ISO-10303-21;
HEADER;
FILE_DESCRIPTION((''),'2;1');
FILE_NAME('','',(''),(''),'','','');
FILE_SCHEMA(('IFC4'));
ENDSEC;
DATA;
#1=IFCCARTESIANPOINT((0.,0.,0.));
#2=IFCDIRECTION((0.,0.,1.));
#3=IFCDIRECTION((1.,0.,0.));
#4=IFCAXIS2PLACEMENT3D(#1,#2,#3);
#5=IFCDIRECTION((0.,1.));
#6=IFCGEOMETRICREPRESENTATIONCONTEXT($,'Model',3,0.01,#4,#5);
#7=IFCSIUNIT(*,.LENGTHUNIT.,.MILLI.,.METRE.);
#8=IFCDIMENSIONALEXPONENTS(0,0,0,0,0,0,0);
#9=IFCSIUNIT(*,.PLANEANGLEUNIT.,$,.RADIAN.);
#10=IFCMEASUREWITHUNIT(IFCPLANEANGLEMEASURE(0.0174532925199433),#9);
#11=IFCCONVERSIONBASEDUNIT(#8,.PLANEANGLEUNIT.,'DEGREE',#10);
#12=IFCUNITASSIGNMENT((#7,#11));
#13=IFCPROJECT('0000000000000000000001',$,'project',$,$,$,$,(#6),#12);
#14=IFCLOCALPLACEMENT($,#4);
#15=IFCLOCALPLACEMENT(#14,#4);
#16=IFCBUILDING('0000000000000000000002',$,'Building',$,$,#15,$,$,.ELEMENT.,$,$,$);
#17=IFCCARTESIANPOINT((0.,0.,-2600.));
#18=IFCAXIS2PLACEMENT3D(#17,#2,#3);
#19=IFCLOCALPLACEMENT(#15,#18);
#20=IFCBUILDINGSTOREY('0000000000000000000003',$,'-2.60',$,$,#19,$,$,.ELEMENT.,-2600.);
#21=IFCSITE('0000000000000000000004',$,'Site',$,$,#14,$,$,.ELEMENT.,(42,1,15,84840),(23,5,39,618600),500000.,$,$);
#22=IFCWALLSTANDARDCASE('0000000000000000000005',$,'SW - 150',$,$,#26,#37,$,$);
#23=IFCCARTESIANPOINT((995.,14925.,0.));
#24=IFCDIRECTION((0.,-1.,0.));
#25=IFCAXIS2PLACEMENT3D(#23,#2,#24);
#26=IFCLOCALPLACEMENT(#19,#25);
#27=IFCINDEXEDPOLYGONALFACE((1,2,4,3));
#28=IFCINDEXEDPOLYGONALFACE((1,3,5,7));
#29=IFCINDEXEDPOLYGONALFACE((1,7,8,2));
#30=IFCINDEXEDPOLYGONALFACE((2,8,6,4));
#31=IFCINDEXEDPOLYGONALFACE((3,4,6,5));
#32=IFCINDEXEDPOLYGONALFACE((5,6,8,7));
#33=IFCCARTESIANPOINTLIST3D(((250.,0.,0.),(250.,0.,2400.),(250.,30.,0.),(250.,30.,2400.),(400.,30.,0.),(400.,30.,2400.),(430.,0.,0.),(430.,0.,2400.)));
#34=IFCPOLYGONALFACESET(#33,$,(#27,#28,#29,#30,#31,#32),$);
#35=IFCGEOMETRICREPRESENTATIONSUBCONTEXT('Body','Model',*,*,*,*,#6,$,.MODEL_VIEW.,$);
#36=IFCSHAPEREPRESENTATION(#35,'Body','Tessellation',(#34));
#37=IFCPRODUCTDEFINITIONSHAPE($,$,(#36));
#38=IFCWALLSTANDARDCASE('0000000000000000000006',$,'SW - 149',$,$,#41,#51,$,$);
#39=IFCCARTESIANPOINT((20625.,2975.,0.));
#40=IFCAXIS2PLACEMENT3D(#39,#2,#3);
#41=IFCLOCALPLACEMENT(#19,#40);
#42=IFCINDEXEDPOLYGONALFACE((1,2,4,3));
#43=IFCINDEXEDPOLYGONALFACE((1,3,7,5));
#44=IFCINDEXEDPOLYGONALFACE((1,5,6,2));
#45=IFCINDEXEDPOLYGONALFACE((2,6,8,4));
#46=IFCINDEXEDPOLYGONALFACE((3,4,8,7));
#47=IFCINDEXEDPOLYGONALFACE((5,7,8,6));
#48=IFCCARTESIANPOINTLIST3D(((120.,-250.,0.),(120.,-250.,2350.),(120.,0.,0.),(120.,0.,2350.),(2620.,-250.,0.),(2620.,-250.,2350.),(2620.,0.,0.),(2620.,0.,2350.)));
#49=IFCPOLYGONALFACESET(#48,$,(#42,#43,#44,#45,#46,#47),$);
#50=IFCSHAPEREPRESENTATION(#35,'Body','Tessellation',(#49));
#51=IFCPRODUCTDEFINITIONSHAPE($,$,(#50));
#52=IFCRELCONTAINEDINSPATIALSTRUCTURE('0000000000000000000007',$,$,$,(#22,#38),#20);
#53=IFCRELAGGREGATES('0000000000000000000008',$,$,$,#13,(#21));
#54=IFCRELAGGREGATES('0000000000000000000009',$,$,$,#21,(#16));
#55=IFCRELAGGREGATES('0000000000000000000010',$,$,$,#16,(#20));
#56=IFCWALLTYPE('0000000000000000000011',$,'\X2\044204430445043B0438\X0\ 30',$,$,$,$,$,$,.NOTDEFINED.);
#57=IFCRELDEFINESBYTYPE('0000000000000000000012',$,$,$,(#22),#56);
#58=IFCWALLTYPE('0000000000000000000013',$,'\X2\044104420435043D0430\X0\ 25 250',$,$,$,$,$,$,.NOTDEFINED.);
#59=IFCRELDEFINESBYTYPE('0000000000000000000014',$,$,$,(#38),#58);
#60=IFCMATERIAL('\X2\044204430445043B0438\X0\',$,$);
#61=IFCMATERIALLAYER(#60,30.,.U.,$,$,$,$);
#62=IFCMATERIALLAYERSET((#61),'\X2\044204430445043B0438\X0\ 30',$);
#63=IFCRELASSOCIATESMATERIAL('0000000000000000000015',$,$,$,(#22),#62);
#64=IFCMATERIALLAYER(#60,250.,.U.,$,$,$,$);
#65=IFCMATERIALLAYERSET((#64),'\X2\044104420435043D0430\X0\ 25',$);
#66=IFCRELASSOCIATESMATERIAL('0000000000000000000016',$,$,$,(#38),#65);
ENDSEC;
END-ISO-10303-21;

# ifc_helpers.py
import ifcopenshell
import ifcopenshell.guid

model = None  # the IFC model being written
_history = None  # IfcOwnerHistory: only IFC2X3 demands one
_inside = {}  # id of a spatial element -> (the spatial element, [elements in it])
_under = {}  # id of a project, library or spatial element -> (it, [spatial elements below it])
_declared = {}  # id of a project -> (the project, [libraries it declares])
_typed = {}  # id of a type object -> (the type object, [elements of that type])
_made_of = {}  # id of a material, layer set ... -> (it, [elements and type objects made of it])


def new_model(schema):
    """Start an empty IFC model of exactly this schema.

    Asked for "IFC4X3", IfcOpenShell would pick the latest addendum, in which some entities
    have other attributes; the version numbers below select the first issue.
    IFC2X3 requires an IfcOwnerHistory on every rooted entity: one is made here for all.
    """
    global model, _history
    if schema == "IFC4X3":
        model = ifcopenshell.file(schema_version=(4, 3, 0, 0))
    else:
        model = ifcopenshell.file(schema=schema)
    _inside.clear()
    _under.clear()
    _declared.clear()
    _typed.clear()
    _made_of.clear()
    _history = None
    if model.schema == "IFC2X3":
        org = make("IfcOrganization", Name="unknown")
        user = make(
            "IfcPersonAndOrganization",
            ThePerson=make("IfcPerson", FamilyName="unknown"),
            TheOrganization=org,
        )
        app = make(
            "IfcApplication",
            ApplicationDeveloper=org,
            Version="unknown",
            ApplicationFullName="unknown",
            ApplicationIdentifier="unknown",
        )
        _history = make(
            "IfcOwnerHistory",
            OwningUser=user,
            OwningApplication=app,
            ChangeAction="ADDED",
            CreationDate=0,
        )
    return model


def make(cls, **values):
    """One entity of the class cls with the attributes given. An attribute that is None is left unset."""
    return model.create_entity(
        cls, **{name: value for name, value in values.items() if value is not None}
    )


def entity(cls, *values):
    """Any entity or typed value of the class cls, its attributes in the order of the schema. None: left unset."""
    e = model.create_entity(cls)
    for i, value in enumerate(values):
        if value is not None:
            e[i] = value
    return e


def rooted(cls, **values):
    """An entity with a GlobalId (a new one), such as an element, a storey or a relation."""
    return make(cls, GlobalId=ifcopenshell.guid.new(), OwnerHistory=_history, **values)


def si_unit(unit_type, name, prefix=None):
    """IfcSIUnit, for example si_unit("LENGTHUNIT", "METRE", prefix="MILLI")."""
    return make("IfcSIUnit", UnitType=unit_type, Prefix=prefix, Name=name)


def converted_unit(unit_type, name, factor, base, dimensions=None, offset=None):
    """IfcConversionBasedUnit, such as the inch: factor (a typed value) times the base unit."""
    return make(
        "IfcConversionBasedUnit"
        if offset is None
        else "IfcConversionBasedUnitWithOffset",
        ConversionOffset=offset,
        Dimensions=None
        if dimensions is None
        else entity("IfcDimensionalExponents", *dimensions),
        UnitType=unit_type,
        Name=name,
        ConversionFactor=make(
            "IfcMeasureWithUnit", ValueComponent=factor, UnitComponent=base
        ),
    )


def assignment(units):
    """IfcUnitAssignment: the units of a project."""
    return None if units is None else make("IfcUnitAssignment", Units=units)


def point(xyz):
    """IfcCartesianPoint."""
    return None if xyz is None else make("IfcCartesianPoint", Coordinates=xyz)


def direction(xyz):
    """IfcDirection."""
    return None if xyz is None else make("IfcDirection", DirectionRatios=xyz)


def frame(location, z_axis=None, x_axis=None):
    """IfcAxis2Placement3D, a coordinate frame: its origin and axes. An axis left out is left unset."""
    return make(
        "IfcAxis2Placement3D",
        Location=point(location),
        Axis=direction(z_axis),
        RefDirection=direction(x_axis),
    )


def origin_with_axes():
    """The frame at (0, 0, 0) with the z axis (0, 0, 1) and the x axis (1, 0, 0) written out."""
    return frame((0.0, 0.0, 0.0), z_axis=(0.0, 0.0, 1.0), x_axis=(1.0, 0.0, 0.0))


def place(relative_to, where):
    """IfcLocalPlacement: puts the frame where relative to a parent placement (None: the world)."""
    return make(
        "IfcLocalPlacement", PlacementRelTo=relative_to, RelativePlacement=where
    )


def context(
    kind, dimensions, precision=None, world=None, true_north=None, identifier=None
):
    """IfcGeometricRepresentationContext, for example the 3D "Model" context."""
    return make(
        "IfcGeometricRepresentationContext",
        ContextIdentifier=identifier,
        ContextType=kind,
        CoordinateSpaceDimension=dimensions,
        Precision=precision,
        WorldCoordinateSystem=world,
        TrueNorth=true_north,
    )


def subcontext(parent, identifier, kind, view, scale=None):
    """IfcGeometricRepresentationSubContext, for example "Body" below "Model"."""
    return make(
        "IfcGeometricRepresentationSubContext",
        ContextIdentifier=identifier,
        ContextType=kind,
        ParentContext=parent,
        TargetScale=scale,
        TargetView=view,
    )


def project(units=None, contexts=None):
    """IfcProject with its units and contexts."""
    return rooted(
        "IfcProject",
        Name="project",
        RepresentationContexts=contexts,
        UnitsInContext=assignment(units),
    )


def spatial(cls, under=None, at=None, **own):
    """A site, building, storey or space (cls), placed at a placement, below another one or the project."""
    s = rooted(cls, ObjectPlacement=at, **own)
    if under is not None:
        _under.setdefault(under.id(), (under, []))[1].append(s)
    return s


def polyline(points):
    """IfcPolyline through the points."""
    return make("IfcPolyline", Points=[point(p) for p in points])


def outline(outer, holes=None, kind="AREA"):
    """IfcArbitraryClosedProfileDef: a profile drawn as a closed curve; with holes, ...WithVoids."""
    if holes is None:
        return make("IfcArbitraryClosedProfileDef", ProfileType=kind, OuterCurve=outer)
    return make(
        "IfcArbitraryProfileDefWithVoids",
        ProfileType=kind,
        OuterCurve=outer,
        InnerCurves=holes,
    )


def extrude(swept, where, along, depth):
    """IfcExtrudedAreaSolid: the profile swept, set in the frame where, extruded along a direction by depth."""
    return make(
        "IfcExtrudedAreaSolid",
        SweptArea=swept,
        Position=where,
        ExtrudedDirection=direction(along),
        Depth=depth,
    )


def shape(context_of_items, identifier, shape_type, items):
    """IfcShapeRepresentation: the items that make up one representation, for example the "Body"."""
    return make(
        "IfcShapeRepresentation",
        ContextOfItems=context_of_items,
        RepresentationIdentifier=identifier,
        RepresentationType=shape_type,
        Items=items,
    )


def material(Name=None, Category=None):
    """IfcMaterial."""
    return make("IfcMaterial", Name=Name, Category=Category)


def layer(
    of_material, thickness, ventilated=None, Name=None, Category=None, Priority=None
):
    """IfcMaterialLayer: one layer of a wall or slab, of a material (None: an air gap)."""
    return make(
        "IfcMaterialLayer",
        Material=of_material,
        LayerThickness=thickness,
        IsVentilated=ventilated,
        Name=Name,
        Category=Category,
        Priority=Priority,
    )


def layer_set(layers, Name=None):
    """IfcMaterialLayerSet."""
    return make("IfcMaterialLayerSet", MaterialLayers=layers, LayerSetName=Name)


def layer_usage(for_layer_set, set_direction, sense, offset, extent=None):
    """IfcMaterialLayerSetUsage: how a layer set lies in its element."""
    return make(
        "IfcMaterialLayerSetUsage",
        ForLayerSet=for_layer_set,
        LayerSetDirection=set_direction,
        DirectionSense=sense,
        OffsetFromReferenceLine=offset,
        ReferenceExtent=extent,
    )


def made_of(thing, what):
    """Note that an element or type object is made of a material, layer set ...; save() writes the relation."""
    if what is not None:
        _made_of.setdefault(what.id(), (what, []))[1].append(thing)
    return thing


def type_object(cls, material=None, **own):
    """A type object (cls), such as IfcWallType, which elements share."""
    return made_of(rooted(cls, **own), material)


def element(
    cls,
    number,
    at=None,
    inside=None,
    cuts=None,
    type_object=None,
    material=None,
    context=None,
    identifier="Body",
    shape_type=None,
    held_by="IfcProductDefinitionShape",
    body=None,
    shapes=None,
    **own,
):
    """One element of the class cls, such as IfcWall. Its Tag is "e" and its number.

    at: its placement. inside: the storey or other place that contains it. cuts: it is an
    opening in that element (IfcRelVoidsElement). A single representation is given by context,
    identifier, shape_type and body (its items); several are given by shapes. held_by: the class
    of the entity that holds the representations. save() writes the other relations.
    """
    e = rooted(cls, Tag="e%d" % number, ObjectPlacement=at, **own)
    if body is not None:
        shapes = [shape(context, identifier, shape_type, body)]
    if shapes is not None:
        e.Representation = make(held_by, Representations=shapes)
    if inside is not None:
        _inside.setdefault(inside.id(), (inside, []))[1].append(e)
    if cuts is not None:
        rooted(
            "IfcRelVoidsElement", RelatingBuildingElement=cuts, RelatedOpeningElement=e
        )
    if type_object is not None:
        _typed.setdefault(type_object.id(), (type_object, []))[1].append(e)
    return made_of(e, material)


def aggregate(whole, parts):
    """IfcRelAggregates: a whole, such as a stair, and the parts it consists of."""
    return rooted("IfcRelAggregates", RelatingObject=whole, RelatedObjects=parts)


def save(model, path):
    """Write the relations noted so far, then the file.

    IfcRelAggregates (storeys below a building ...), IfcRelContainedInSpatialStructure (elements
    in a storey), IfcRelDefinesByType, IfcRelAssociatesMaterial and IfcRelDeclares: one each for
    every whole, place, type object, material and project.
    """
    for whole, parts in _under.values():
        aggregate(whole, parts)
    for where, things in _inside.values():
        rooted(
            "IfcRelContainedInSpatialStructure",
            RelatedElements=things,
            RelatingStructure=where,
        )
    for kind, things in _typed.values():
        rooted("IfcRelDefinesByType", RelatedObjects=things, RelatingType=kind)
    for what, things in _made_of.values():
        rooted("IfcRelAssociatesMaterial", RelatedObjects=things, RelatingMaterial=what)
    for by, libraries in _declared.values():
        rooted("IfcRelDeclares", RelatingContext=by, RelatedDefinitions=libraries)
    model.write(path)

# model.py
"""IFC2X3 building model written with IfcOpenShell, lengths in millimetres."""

from ifc_helpers import new_model, entity, si_unit, converted_unit, direction, frame, origin_with_axes, place, context, subcontext, project, spatial, polyline, outline, extrude, material, layer, layer_set, layer_usage, type_object, element, save


model = new_model("IFC2X3")

# Units and contexts
model_context = context("Model", 3, precision=0.01, world=origin_with_axes(), true_north=direction((0.0, 1.0)))
body_context = subcontext(model_context, "Body", "Model", "MODEL_VIEW")
ifc_project = project(units=[si_unit("LENGTHUNIT", "METRE", prefix="MILLI"), converted_unit("PLANEANGLEUNIT", "DEGREE", entity("IfcPlaneAngleMeasure", 0.0174532925199433), si_unit("PLANEANGLEUNIT", "RADIAN"), dimensions=[0, 0, 0, 0, 0, 0, 0])], contexts=[model_context])

# Site, building, storey
site_placement = place(None, origin_with_axes())
site = spatial("IfcSite", under=ifc_project, at=site_placement, Name="Site", CompositionType="ELEMENT", RefLatitude=(42, 1, 15, 84840), RefLongitude=(23, 5, 39, 618600), RefElevation=500000.0)
building_placement = place(site_placement, origin_with_axes())
building = spatial("IfcBuilding", under=site, at=building_placement, Name="Building", CompositionType="ELEMENT")
storey_placement = place(building_placement, frame((0.0, 0.0, -2600.0), z_axis=(0.0, 0.0, 1.0), x_axis=(1.0, 0.0, 0.0)))
storey = spatial("IfcBuildingStorey", under=building, at=storey_placement, Name="-2.60", CompositionType="ELEMENT", Elevation=-2600.0)

# Shared definitions
ifc_material_1 = material(Name="тухли")

# Wall
ifc_layer_1 = layer(ifc_material_1, 30.0, ventilated="UNKNOWN")
ifc_layer_set_1 = layer_set([ifc_layer_1], Name="тухли 30")
wall_type_1 = type_object("IfcWallType", Name="тухли 30", PredefinedType="NOTDEFINED")
ifc_layer_usage_1 = layer_usage(ifc_layer_set_1, "AXIS2", "POSITIVE", 0.0)
wall_1_placement = place(storey_placement, frame((995.0, 14925.0, 0.0), z_axis=(0.0, 0.0, 1.0), x_axis=(0.0, -1.0, 0.0)))
element("IfcWallStandardCase", 1, at=wall_1_placement, inside=storey, type_object=wall_type_1, material=ifc_layer_usage_1, Name="SW - 150", context=body_context, shape_type="SweptSolid", body=[
    extrude(outline(polyline([(250.0, 0.0), (430.0, 0.0), (400.0, 30.0), (250.0, 30.0), (250.0, 0.0)])), origin_with_axes(), (0.0, 0.0, 1.0), 2400.0),
])

# Shared definitions
ifc_layer_2 = layer(ifc_material_1, 250.0, ventilated="UNKNOWN")
ifc_layer_set_2 = layer_set([ifc_layer_2], Name="стена 25")
wall_type_2 = type_object("IfcWallType", Name="стена 25 250", PredefinedType="NOTDEFINED")

# Wall
ifc_layer_usage_2 = layer_usage(ifc_layer_set_2, "AXIS2", "NEGATIVE", 0.0)
wall_2_placement = place(storey_placement, frame((20625.0, 2975.0, 0.0), z_axis=(0.0, 0.0, 1.0), x_axis=(1.0, 0.0, 0.0)))
element("IfcWallStandardCase", 2, at=wall_2_placement, inside=storey, type_object=wall_type_2, material=ifc_layer_usage_2, Name="SW - 149", context=body_context, shape_type="SweptSolid", body=[
    extrude(outline(polyline([(120.0, -250.0), (2620.0, -250.0), (2620.0, 0.0), (120.0, 0.0), (120.0, -250.0)])), origin_with_axes(), (0.0, 0.0, 1.0), 2350.0),
])

save(model, "model.ifc")
